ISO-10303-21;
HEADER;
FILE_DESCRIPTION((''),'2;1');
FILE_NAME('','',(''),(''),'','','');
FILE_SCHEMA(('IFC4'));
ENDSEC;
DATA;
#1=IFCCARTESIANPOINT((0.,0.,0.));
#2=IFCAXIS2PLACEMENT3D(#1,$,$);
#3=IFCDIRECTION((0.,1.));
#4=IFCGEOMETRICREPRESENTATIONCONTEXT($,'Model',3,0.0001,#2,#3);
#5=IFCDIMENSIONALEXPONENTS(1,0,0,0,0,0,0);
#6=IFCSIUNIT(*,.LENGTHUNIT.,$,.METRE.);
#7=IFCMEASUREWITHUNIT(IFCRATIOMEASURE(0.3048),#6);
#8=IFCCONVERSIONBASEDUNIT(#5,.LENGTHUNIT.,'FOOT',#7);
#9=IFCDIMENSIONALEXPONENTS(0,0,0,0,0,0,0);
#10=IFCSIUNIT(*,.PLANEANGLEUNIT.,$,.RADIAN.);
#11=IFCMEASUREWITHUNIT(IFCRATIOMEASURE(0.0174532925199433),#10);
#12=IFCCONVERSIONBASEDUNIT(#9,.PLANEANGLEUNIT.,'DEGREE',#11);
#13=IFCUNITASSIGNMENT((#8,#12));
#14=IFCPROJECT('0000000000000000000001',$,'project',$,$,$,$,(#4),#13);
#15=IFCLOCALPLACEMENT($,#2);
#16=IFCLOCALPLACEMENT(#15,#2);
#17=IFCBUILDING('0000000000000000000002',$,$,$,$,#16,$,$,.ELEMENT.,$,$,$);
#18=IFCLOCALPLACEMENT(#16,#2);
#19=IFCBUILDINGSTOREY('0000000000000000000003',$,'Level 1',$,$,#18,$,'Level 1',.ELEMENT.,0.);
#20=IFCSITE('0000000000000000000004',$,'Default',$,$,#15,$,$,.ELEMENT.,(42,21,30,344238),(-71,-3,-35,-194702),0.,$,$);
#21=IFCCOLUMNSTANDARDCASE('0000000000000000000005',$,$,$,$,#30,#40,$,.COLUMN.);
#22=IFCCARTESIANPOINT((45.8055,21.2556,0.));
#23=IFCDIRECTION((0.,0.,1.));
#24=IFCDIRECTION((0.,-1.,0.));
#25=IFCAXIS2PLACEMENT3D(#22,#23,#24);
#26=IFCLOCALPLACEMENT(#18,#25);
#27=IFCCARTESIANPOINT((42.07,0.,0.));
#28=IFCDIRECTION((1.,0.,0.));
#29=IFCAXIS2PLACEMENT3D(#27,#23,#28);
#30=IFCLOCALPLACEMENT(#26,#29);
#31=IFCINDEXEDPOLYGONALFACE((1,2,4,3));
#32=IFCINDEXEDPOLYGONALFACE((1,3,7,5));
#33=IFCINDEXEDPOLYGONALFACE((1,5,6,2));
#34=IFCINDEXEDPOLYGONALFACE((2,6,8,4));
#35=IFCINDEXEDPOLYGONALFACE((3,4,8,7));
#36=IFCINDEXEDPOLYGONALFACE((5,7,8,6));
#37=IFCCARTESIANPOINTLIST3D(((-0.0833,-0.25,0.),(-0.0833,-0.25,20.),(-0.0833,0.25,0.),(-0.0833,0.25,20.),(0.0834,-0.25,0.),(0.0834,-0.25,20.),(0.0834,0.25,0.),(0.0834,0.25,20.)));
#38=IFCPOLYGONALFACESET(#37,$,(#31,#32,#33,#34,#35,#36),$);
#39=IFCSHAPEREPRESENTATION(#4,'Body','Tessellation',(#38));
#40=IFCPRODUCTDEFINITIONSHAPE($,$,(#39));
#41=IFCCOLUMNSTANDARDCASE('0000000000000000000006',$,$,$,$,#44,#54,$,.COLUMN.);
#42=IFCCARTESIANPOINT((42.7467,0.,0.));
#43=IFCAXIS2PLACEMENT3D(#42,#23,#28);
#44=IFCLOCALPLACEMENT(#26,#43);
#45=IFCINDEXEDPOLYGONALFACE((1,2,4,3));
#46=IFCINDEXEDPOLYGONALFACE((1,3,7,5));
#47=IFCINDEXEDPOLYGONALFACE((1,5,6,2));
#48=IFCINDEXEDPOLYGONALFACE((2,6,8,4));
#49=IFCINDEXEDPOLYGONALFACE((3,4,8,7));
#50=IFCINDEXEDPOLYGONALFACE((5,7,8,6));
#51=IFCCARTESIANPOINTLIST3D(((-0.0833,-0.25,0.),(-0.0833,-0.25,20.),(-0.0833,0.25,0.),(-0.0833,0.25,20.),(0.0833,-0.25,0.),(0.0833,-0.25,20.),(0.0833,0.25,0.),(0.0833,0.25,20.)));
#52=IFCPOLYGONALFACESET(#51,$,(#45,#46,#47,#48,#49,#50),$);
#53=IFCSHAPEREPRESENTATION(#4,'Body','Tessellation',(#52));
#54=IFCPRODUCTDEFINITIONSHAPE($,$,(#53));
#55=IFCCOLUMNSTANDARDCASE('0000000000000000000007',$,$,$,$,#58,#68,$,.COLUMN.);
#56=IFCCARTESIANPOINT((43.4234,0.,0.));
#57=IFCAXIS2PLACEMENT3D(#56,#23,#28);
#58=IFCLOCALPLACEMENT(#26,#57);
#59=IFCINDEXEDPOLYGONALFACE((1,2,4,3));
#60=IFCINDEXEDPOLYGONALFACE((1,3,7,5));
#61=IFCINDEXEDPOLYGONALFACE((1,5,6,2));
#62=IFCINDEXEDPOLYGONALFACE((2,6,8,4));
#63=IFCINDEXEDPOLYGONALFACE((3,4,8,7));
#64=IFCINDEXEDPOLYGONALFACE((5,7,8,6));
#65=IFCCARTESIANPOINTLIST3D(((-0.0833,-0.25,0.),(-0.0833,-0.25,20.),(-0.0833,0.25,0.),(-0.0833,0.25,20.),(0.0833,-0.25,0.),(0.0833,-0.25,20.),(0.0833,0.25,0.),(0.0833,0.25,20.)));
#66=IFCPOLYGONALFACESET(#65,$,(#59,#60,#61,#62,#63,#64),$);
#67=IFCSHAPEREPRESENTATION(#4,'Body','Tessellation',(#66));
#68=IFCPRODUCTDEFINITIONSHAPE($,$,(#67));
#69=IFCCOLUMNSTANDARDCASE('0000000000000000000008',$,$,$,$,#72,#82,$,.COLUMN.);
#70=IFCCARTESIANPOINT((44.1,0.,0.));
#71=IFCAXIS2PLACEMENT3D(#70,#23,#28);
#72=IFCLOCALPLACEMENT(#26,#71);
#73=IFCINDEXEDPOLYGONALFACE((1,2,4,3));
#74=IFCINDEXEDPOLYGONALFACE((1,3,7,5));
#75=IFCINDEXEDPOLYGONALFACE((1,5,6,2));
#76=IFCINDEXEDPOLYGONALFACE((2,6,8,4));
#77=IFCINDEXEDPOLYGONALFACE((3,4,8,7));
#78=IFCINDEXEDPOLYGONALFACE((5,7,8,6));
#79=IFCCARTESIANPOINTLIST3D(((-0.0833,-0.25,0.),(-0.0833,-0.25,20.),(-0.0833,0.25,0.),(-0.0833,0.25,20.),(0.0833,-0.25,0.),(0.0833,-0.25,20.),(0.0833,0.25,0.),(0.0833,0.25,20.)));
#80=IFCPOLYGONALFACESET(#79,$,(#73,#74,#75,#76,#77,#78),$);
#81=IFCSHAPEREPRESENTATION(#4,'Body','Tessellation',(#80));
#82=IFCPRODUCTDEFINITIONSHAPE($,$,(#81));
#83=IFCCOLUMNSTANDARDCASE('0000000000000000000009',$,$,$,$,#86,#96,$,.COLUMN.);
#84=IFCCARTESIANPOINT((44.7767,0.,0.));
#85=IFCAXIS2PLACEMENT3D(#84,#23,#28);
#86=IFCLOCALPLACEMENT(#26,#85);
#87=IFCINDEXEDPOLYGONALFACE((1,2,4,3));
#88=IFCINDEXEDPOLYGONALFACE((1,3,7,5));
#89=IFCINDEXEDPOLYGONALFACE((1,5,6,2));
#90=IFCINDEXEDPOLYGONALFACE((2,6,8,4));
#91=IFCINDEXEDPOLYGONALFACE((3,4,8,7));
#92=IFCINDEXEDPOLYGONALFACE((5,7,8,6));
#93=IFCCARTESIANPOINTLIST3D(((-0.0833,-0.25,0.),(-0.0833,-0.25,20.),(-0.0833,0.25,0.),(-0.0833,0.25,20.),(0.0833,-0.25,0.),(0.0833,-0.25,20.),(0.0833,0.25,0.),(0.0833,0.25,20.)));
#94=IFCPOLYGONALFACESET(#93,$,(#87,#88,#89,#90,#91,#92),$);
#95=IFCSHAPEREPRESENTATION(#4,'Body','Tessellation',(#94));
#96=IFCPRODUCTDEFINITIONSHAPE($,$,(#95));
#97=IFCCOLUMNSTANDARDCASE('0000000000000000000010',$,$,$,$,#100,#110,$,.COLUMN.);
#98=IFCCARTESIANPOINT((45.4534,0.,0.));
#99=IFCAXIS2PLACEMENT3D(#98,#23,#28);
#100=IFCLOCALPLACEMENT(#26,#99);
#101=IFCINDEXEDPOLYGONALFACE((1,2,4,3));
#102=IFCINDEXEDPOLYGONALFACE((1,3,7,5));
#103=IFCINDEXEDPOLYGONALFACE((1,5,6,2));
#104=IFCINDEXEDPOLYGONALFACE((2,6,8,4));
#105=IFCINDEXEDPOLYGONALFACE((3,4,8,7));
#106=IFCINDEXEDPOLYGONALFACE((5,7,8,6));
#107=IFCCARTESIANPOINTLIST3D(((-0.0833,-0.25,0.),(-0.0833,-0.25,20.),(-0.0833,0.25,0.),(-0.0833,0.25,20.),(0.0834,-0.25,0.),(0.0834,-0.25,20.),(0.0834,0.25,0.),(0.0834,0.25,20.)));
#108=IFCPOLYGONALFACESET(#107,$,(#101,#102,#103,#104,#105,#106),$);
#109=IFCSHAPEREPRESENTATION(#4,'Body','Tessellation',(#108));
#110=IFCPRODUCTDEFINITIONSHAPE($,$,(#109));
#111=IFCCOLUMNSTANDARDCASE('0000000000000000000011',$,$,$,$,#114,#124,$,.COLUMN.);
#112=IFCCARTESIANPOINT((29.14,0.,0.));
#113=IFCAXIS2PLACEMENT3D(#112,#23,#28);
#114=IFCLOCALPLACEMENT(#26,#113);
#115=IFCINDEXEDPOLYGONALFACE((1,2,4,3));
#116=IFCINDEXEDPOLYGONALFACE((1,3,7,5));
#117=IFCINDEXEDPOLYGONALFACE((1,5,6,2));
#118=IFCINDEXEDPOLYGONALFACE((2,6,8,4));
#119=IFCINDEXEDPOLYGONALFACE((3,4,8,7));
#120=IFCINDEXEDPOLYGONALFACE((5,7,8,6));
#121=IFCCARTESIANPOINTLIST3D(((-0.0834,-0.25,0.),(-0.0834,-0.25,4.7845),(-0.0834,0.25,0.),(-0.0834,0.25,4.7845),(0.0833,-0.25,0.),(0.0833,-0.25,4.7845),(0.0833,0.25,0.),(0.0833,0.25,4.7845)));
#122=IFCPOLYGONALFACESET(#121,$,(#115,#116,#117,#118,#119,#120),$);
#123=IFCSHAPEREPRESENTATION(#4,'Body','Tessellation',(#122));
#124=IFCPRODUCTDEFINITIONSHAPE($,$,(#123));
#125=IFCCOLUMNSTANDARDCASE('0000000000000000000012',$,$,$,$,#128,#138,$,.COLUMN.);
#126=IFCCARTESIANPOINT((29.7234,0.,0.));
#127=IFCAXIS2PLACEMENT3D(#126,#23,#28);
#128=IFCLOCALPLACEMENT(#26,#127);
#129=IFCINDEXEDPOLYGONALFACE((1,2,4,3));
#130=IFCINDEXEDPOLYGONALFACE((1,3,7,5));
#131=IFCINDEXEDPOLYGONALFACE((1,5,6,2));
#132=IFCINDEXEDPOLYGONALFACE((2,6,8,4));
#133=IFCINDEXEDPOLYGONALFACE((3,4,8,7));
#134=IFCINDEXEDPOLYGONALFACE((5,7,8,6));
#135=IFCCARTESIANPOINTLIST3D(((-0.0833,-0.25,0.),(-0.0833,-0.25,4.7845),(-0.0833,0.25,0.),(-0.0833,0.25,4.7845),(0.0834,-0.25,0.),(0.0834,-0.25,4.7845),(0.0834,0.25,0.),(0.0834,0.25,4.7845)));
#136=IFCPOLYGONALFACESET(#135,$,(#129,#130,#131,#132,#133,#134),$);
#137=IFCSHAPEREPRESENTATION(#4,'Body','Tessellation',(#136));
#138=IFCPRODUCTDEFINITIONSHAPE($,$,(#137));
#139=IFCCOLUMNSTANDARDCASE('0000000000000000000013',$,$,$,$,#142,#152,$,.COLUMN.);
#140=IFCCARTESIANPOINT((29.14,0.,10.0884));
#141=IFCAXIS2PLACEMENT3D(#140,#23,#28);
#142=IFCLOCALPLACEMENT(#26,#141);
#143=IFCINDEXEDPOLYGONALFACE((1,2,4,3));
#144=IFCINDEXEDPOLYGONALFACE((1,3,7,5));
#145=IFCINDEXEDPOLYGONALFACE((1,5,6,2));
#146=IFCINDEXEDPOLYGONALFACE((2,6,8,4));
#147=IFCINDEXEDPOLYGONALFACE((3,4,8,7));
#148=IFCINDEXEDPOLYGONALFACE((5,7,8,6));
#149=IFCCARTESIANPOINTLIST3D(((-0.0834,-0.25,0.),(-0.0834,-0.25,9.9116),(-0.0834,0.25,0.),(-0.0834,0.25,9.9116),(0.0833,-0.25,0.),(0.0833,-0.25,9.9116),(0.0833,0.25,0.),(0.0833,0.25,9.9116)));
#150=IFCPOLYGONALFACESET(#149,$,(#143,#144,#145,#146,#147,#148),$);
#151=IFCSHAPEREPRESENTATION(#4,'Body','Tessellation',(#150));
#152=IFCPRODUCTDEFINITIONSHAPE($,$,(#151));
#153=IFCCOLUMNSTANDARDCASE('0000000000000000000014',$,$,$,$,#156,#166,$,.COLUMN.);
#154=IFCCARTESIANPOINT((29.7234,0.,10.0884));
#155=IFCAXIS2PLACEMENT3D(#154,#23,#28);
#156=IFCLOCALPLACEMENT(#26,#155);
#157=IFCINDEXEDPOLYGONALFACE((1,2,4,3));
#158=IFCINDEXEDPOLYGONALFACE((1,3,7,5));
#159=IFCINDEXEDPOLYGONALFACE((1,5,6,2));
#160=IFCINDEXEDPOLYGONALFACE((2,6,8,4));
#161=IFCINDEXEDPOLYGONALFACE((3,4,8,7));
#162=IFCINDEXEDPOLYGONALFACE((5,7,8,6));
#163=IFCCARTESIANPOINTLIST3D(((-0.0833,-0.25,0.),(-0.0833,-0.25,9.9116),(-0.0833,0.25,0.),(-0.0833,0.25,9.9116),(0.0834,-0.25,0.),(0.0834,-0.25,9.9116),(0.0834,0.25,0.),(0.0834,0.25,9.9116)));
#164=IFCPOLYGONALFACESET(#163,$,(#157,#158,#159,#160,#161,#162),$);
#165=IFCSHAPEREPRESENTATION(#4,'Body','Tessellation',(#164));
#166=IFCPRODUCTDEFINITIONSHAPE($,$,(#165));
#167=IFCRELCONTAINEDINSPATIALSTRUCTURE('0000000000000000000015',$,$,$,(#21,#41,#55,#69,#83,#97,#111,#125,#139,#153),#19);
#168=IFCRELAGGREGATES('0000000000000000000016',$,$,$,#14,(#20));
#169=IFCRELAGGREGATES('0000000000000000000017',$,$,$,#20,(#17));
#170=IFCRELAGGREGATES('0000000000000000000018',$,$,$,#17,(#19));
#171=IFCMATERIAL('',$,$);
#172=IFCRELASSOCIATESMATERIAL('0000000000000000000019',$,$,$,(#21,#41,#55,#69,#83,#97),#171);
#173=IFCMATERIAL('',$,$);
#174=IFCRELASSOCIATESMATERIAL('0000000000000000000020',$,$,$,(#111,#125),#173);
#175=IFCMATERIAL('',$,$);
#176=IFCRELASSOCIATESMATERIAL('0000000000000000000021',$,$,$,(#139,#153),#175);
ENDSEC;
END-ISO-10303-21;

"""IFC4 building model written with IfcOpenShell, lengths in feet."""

from ifc_helpers import new_model, entity, si_unit, converted_unit, direction, frame, origin, place, context, project, spatial, rectangle, extrude, material, element, save


model = new_model("IFC4")

# Units and contexts
model_context = context("Model", 3, precision=0.0001, world=origin(), true_north=direction((0.0, 1.0)))
ifc_project = project(units=[converted_unit("LENGTHUNIT", "FOOT", entity("IfcRatioMeasure", 0.3048), si_unit("LENGTHUNIT", "METRE"), dimensions=[1, 0, 0, 0, 0, 0, 0]), converted_unit("PLANEANGLEUNIT", "DEGREE", entity("IfcRatioMeasure", 0.0174532925199433), si_unit("PLANEANGLEUNIT", "RADIAN"), dimensions=[0, 0, 0, 0, 0, 0, 0])], contexts=[model_context])

# Site, building, storey
site_placement = place(None, origin())
site = spatial("IfcSite", under=ifc_project, at=site_placement, Name="Default", CompositionType="ELEMENT", RefLatitude=(42, 21, 30, 344238), RefLongitude=(-71, -3, -35, -194702), RefElevation=0.0)
building_placement = place(site_placement, origin())
building = spatial("IfcBuilding", under=site, at=building_placement, CompositionType="ELEMENT")
storey_placement = place(building_placement, origin())
storey = spatial("IfcBuildingStorey", under=building, at=storey_placement, Name="Level 1", LongName="Level 1", CompositionType="ELEMENT", Elevation=0.0)

# Columns
ifc_material_1 = material(Name="")
placement = place(storey_placement, frame((45.8055, 21.2556, 0.0), z_axis=(0.0, 0.0, 1.0), x_axis=(0.0, -1.0, 0.0)))
for number, where, z_axis, x_axis in (
    (1, (42.07, 0.0, 0.0), (0.0, 0.0, 1.0), (1.0, 0.0, 0.0)),
    (2, (42.7467, 0.0, 0.0), (0.0, 0.0, 1.0), (1.0, 0.0, 0.0)),
    (3, (43.4234, 0.0, 0.0), (0.0, 0.0, 1.0), (1.0, 0.0, 0.0)),
    (4, (44.1, 0.0, 0.0), (0.0, 0.0, 1.0), (1.0, 0.0, 0.0)),
    (5, (44.7767, 0.0, 0.0), (0.0, 0.0, 1.0), (1.0, 0.0, 0.0)),
    (6, (45.4534, 0.0, 0.0), (0.0, 0.0, 1.0), (1.0, 0.0, 0.0)),
):
    element("IfcColumnStandardCase", number, at=place(placement, frame(where, z_axis=z_axis, x_axis=x_axis)), inside=storey, material=ifc_material_1, PredefinedType="COLUMN", context=model_context, shape_type="SweptSolid", body=[
        extrude(rectangle(XDim=0.1667, YDim=0.5), origin(), (0.0, 0.0, 1.0), 20.0),
    ])
ifc_material_2 = material(Name="")
for number, where, z_axis, x_axis in (
    (7, (29.14, 0.0, 0.0), (0.0, 0.0, 1.0), (1.0, 0.0, 0.0)),
    (8, (29.7234, 0.0, 0.0), (0.0, 0.0, 1.0), (1.0, 0.0, 0.0)),
):
    element("IfcColumnStandardCase", number, at=place(placement, frame(where, z_axis=z_axis, x_axis=x_axis)), inside=storey, material=ifc_material_2, PredefinedType="COLUMN", context=model_context, shape_type="SweptSolid", body=[
        extrude(rectangle(XDim=0.1667, YDim=0.5), origin(), (0.0, 0.0, 1.0), 4.7845),
    ])
ifc_material_3 = material(Name="")
for number, where, z_axis, x_axis in (
    (9, (29.14, 0.0, 10.0884), (0.0, 0.0, 1.0), (1.0, 0.0, 0.0)),
    (10, (29.7234, 0.0, 10.0884), (0.0, 0.0, 1.0), (1.0, 0.0, 0.0)),
):
    element("IfcColumnStandardCase", number, at=place(placement, frame(where, z_axis=z_axis, x_axis=x_axis)), inside=storey, material=ifc_material_3, PredefinedType="COLUMN", context=model_context, shape_type="SweptSolid", body=[
        extrude(rectangle(XDim=0.1667, YDim=0.5), origin(), (0.0, 0.0, 1.0), 9.9116),
    ])

save(model, "model.ifc")
